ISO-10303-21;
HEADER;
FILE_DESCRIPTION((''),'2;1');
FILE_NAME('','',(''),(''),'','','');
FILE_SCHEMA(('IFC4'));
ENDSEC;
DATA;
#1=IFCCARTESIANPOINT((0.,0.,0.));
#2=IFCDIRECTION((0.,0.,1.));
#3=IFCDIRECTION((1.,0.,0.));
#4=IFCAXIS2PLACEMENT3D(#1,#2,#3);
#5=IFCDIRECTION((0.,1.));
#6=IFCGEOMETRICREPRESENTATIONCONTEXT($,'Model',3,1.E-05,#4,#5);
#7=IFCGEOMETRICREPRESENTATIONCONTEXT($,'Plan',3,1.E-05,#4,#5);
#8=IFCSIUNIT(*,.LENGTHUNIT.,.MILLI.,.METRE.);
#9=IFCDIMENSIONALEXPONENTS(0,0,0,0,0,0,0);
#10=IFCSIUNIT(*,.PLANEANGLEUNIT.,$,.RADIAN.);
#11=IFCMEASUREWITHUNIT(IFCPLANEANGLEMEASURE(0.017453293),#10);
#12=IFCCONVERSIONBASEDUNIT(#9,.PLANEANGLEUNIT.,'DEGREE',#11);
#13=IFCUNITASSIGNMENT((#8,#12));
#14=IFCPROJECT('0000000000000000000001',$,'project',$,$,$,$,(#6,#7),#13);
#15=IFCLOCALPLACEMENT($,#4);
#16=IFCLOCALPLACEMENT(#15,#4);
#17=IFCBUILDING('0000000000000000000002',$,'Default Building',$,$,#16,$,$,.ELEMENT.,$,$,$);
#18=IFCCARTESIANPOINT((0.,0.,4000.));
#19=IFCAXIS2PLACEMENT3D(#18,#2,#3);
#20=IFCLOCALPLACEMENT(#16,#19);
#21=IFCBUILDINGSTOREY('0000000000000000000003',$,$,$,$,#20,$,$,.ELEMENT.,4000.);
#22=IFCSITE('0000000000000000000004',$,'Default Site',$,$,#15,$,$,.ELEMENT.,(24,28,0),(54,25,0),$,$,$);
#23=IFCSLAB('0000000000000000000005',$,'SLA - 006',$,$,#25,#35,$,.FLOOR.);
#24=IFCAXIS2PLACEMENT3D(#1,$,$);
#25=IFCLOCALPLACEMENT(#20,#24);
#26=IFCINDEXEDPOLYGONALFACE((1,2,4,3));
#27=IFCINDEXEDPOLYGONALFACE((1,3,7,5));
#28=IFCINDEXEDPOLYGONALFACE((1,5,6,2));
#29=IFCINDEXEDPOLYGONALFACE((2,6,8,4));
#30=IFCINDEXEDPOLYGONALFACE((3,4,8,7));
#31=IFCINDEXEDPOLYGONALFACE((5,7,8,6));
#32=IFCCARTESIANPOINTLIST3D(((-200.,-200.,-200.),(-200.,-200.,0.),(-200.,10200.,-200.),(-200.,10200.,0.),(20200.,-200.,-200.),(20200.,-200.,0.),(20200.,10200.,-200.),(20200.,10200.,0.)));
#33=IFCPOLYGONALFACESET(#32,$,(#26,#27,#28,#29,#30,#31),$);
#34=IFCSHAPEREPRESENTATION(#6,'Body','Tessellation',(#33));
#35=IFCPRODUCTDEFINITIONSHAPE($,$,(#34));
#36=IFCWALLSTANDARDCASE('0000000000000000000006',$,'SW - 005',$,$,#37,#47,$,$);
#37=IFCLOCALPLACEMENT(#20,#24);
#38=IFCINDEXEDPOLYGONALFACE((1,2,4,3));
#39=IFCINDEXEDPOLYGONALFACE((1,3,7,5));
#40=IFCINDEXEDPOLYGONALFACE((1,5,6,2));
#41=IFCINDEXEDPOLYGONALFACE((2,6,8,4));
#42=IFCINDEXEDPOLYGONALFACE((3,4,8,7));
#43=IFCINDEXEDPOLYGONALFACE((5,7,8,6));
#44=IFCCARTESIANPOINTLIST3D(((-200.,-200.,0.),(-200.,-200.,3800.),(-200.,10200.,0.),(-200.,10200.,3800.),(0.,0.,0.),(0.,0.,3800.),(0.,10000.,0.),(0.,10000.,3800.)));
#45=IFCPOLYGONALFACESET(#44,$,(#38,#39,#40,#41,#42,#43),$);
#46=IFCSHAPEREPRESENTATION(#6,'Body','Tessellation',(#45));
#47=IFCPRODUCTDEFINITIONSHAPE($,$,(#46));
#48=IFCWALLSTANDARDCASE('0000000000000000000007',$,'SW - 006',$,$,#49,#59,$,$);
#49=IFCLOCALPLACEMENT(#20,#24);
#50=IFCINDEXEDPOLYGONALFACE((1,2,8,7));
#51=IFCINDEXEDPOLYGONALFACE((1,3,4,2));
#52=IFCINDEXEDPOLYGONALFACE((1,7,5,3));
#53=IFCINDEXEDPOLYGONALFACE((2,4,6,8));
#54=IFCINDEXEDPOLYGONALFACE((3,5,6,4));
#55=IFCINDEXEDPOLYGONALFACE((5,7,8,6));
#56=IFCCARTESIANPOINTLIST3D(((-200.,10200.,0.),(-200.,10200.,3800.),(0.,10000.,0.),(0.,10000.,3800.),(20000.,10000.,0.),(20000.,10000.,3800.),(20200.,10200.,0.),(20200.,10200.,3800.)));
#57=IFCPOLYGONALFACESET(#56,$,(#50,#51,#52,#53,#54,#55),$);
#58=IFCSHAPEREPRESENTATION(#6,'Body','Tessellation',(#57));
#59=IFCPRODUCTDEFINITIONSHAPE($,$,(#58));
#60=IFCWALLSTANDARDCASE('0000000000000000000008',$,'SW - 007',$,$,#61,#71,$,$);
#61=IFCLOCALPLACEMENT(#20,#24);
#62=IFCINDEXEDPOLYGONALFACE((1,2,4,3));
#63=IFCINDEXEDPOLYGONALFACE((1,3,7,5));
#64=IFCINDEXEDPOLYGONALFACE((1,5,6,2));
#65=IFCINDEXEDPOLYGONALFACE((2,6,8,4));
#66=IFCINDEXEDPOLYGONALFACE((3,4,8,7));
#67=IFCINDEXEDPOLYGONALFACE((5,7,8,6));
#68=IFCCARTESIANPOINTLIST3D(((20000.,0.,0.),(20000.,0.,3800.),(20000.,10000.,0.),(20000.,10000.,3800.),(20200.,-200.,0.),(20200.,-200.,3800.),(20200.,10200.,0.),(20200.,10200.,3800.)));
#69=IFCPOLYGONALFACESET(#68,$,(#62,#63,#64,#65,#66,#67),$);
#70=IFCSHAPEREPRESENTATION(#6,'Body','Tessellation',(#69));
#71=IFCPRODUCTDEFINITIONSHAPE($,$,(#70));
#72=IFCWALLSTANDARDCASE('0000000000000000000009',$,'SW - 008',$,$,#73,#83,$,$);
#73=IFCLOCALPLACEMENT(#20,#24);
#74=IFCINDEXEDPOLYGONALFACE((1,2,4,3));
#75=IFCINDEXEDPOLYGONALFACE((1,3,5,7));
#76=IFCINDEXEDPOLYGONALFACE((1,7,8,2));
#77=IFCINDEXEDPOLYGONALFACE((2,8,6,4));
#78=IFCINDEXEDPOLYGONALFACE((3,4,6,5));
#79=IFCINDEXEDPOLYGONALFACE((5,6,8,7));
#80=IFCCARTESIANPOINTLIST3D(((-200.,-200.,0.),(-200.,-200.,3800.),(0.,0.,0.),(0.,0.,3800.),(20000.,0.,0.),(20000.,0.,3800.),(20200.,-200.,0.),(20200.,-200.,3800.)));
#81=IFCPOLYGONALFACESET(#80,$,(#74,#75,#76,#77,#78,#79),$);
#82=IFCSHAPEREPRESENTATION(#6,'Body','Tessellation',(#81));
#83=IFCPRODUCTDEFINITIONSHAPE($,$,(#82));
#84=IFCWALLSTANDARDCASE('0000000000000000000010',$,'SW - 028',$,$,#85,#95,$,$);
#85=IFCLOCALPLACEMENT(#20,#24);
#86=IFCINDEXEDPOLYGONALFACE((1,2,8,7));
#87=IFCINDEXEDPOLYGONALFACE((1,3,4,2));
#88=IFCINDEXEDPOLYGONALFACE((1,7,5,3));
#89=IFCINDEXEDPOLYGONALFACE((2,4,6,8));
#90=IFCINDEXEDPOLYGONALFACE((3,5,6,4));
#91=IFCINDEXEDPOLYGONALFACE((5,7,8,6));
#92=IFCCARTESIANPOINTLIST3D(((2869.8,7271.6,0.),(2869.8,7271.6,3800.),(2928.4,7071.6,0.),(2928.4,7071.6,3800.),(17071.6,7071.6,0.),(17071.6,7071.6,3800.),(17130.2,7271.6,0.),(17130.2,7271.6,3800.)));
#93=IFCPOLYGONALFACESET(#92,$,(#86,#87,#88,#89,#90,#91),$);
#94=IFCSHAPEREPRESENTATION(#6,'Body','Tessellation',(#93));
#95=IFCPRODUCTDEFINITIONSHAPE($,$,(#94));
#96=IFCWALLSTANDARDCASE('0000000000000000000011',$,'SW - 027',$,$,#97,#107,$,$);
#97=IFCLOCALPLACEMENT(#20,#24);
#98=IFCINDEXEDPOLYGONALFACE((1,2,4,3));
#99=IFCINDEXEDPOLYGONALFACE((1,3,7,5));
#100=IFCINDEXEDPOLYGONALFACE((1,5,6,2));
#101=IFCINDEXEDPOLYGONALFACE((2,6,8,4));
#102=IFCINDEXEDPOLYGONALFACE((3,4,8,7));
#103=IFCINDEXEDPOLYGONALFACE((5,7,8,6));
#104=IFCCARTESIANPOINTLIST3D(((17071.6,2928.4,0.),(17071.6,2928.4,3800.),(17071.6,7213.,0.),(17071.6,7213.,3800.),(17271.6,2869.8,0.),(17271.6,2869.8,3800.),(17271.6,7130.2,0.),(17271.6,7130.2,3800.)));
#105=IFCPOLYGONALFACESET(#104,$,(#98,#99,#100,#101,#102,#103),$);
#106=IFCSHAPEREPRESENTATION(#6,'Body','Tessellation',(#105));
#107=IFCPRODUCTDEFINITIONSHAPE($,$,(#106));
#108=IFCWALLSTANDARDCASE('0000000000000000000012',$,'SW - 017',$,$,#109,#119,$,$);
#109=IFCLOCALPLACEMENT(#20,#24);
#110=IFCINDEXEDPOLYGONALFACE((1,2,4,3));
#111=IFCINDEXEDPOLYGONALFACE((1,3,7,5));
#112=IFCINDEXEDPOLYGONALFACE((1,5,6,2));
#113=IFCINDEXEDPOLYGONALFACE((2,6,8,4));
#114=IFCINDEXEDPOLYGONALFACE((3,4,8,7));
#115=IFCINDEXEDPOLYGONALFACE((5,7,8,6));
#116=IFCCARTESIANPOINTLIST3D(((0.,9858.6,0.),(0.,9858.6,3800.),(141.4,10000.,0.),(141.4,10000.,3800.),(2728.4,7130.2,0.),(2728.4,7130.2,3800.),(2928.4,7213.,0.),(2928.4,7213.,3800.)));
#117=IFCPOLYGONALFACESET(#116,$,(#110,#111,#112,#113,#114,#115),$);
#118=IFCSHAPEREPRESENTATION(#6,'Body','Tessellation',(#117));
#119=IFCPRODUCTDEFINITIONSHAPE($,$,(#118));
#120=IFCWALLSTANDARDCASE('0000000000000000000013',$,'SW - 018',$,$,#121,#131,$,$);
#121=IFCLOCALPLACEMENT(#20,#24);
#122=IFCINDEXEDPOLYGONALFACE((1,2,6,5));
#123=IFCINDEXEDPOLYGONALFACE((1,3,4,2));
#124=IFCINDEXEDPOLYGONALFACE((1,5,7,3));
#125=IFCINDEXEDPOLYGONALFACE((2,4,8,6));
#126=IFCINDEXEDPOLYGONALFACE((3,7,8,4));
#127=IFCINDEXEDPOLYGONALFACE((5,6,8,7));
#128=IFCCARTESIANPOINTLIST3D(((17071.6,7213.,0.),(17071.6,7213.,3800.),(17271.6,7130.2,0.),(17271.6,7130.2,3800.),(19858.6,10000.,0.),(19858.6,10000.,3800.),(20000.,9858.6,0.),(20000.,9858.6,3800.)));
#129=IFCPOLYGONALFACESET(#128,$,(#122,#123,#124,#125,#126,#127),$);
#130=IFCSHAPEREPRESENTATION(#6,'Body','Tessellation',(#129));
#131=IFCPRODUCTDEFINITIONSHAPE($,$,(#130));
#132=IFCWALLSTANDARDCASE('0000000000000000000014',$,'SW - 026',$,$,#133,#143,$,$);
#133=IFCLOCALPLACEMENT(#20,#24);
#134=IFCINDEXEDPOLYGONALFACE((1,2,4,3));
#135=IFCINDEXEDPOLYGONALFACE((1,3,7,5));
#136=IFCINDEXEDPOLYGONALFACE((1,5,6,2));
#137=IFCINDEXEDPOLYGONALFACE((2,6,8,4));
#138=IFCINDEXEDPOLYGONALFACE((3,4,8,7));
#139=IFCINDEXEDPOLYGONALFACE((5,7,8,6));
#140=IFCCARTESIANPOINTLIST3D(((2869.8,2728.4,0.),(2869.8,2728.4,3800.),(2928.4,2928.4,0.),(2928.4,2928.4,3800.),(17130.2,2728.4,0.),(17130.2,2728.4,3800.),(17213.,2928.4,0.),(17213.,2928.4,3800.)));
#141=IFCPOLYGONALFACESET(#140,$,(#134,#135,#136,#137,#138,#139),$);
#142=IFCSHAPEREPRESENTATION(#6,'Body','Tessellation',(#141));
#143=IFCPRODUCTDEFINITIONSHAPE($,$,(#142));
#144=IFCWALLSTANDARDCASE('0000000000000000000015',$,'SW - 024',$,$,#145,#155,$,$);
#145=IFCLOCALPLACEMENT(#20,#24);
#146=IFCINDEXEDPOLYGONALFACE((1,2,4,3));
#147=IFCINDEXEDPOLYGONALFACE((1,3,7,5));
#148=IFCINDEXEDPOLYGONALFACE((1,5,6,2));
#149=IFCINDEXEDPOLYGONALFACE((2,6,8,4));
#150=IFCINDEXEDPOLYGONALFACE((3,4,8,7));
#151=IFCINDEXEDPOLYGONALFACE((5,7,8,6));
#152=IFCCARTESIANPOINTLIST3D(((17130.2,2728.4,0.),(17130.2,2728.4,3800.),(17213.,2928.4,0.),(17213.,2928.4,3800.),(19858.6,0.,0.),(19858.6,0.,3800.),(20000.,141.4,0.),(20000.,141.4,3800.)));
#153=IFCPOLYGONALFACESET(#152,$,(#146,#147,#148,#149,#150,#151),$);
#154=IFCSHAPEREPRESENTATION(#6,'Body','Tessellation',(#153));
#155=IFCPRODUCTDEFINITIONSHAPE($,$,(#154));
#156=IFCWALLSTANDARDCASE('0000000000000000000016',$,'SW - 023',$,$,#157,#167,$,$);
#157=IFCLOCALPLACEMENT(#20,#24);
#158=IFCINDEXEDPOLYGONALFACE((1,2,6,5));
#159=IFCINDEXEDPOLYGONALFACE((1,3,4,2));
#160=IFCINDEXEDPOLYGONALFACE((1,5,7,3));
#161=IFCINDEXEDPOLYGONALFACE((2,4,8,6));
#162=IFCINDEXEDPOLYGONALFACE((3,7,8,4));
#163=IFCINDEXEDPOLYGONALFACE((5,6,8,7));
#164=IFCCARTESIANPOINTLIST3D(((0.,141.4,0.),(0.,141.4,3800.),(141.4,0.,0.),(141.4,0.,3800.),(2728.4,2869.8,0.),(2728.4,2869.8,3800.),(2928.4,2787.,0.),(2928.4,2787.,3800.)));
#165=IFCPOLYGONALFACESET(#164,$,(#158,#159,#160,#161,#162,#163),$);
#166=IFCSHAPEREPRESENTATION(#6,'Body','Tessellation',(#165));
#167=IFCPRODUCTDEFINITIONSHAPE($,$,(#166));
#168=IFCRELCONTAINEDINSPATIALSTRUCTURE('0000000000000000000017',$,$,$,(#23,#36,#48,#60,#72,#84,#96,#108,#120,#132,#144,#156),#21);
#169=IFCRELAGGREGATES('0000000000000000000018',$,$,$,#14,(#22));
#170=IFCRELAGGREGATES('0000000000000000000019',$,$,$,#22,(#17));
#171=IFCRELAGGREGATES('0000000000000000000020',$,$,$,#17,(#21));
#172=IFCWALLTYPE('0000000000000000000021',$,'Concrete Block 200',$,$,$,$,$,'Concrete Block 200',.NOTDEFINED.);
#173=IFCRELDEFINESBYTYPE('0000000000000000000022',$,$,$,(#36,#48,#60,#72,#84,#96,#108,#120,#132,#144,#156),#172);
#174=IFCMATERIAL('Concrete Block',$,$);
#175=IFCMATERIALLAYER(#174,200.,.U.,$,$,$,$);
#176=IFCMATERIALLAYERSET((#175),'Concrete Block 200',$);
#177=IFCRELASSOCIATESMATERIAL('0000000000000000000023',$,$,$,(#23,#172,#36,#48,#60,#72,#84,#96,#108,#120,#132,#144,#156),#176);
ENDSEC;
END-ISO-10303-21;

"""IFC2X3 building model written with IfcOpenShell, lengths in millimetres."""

from ifc_helpers import new_model, entity, si_unit, converted_unit, direction, frame, origin_with_axes, place, context, project, spatial, polyline, outline, extrude, material, layer, layer_set, layer_usage, type_object, element, save


model = new_model("IFC2X3")

# Units and contexts
model_context = context("Model", 3, precision=1e-05, world=origin_with_axes(), true_north=direction((0.0, 1.0)))
plan_context = context("Plan", 3, precision=1e-05, world=origin_with_axes(), true_north=direction((0.0, 1.0)))
ifc_project = project(units=[si_unit("LENGTHUNIT", "METRE", prefix="MILLI"), converted_unit("PLANEANGLEUNIT", "DEGREE", entity("IfcPlaneAngleMeasure", 0.017453293), si_unit("PLANEANGLEUNIT", "RADIAN"), dimensions=[0, 0, 0, 0, 0, 0, 0])], contexts=[model_context, plan_context])

# Site, building, storey
site_placement = place(None, origin_with_axes())
site = spatial("IfcSite", under=ifc_project, at=site_placement, Name="Default Site", CompositionType="ELEMENT", RefLatitude=(24, 28, 0), RefLongitude=(54, 25, 0))
building_placement = place(site_placement, origin_with_axes())
building = spatial("IfcBuilding", under=site, at=building_placement, Name="Default Building", CompositionType="ELEMENT")
storey_placement = place(building_placement, frame((0.0, 0.0, 4000.0), z_axis=(0.0, 0.0, 1.0), x_axis=(1.0, 0.0, 0.0)))
storey = spatial("IfcBuildingStorey", under=building, at=storey_placement, CompositionType="ELEMENT", Elevation=4000.0)

# Slab
ifc_material = material(Name="Concrete Block")
ifc_layer = layer(ifc_material, 200.0, ventilated="UNKNOWN")
ifc_layer_set = layer_set([ifc_layer], Name="Concrete Block 200")
ifc_layer_usage_1 = layer_usage(ifc_layer_set, "AXIS3", "NEGATIVE", 200.0)
slab_placement = place(storey_placement, frame((-200.0, 10200.0, -200.0), z_axis=(0.0, 0.0, 1.0), x_axis=(1.0, 0.0, 0.0)))
element("IfcSlab", 1, at=slab_placement, inside=storey, material=ifc_layer_usage_1, Name="SLA - 006", PredefinedType="FLOOR", context=model_context, shape_type="SweptSolid", body=[
    extrude(outline(polyline([(0.0, 0.0), (20400.0, 0.0), (20400.0, -10400.0), (0.0, -10400.0), (0.0, 0.0)])), origin_with_axes(), (0.0, 0.0, 1.0), 200.0),
])

# Walls
ifc_layer_usage_2 = layer_usage(ifc_layer_set, "AXIS2", "POSITIVE", 0.0)
wall_type = type_object("IfcWallType", Name="Concrete Block 200", ElementType="Concrete Block 200", PredefinedType="NOTDEFINED", material=ifc_layer_set)
wall_1_placement = place(storey_placement, frame((0.0, 0.0, 0.0), z_axis=(0.0, 0.0, 1.0), x_axis=(0.0, 1.0, 0.0)))
element("IfcWallStandardCase", 2, at=wall_1_placement, inside=storey, type_object=wall_type, material=ifc_layer_usage_2, Name="SW - 005", context=model_context, shape_type="SweptSolid", body=[
    extrude(outline(polyline([(0.0, 0.0), (10000.0, 0.0), (10200.0, 200.0), (-200.0, 200.0), (0.0, 0.0)])), origin_with_axes(), (0.0, 0.0, 1.0), 3800.0),
])
ifc_layer_usage_3 = layer_usage(ifc_layer_set, "AXIS2", "POSITIVE", 0.0)
wall_2_placement = place(storey_placement, frame((0.0, 10000.0, 0.0), z_axis=(0.0, 0.0, 1.0), x_axis=(1.0, 0.0, 0.0)))
element("IfcWallStandardCase", 3, at=wall_2_placement, inside=storey, type_object=wall_type, material=ifc_layer_usage_3, Name="SW - 006", context=model_context, shape_type="SweptSolid", body=[
    extrude(outline(polyline([(0.0, 0.0), (20000.0, 0.0), (20200.0, 200.0), (-200.0, 200.0), (0.0, 0.0)])), origin_with_axes(), (0.0, 0.0, 1.0), 3800.0),
])
ifc_layer_usage_4 = layer_usage(ifc_layer_set, "AXIS2", "POSITIVE", 0.0)
wall_3_placement = place(storey_placement, frame((20000.0, 10000.0, 0.0), z_axis=(0.0, 0.0, 1.0), x_axis=(0.0, -1.0, 0.0)))
element("IfcWallStandardCase", 4, at=wall_3_placement, inside=storey, type_object=wall_type, material=ifc_layer_usage_4, Name="SW - 007", context=model_context, shape_type="SweptSolid", body=[
    extrude(outline(polyline([(0.0, 0.0), (10000.0, 0.0), (10200.0, 200.0), (-200.0, 200.0), (0.0, 0.0)])), origin_with_axes(), (0.0, 0.0, 1.0), 3800.0),
])
ifc_layer_usage_5 = layer_usage(ifc_layer_set, "AXIS2", "POSITIVE", 0.0)
wall_4_placement = place(storey_placement, frame((20000.0, 0.0, 0.0), z_axis=(0.0, 0.0, 1.0), x_axis=(-1.0, 0.0, 0.0)))
element("IfcWallStandardCase", 5, at=wall_4_placement, inside=storey, type_object=wall_type, material=ifc_layer_usage_5, Name="SW - 008", context=model_context, shape_type="SweptSolid", body=[
    extrude(outline(polyline([(0.0, 0.0), (20000.0, 0.0), (20200.0, 200.0), (-200.0, 200.0), (0.0, 0.0)])), origin_with_axes(), (0.0, 0.0, 1.0), 3800.0),
])
ifc_layer_usage_6 = layer_usage(ifc_layer_set, "AXIS2", "POSITIVE", 0.0)
wall_5_placement = place(storey_placement, frame((2928.4, 7071.6, 0.0), z_axis=(0.0, 0.0, 1.0), x_axis=(1.0, 0.0, 0.0)))
element("IfcWallStandardCase", 6, at=wall_5_placement, inside=storey, type_object=wall_type, material=ifc_layer_usage_6, Name="SW - 028", context=model_context, shape_type="SweptSolid", body=[
    extrude(outline(polyline([(0.0, 0.0), (14143.1, 0.0), (14201.7, 200.0), (-58.6, 200.0), (0.0, 0.0)])), origin_with_axes(), (0.0, 0.0, 1.0), 3800.0),
])
ifc_layer_usage_7 = layer_usage(ifc_layer_set, "AXIS2", "NEGATIVE", 0.0)
wall_6_placement = place(storey_placement, frame((17071.6, 2928.4, 0.0), z_axis=(0.0, 0.0, 1.0), x_axis=(0.0, 1.0, 0.0)))
element("IfcWallStandardCase", 7, at=wall_6_placement, inside=storey, type_object=wall_type, material=ifc_layer_usage_7, Name="SW - 027", context=model_context, shape_type="SweptSolid", body=[
    extrude(outline(polyline([(-58.6, -200.0), (4201.7, -200.0), (4284.6, 0.0), (0.0, 0.0), (-58.6, -200.0)])), origin_with_axes(), (0.0, 0.0, 1.0), 3800.0),
])
ifc_layer_usage_8 = layer_usage(ifc_layer_set, "AXIS2", "NEGATIVE", 100.0)
wall_7_placement = place(storey_placement, frame((0.0, 10000.0, 0.0), z_axis=(0.0, 0.0, 1.0), x_axis=(0.707107, -0.707107, 0.0)))
element("IfcWallStandardCase", 8, at=wall_7_placement, inside=storey, type_object=wall_type, material=ifc_layer_usage_8, Name="SW - 017", context=model_context, shape_type="SweptSolid", body=[
    extrude(outline(polyline([(100.0, -100.0), (3958.6, -100.0), (4041.4, 100.0), (100.0, 100.0), (100.0, -100.0)])), origin_with_axes(), (0.0, 0.0, 1.0), 3800.0),
])
ifc_layer_usage_9 = layer_usage(ifc_layer_set, "AXIS2", "NEGATIVE", 100.0)
wall_8_placement = place(storey_placement, frame((20000.0, 10000.0, 0.0), z_axis=(0.0, 0.0, 1.0), x_axis=(-0.707107, -0.707107, 0.0)))
element("IfcWallStandardCase", 9, at=wall_8_placement, inside=storey, type_object=wall_type, material=ifc_layer_usage_9, Name="SW - 018", context=model_context, shape_type="SweptSolid", body=[
    extrude(outline(polyline([(100.0, -100.0), (4041.4, -100.0), (3958.6, 100.0), (100.0, 100.0), (100.0, -100.0)])), origin_with_axes(), (0.0, 0.0, 1.0), 3800.0),
])
ifc_layer_usage_10 = layer_usage(ifc_layer_set, "AXIS2", "NEGATIVE", 0.0)
wall_9_placement = place(storey_placement, frame((2928.4, 2928.4, 0.0), z_axis=(0.0, 0.0, 1.0), x_axis=(1.0, 0.0, 0.0)))
element("IfcWallStandardCase", 10, at=wall_9_placement, inside=storey, type_object=wall_type, material=ifc_layer_usage_10, Name="SW - 026", context=model_context, shape_type="SweptSolid", body=[
    extrude(outline(polyline([(-58.6, -200.0), (14201.7, -200.0), (14284.6, 0.0), (0.0, 0.0), (-58.6, -200.0)])), origin_with_axes(), (0.0, 0.0, 1.0), 3800.0),
])
ifc_layer_usage_11 = layer_usage(ifc_layer_set, "AXIS2", "NEGATIVE", 100.0)
wall_10_placement = place(storey_placement, frame((20000.0, 0.0, 0.0), z_axis=(0.0, 0.0, 1.0), x_axis=(-0.707107, 0.707107, 0.0)))
element("IfcWallStandardCase", 11, at=wall_10_placement, inside=storey, type_object=wall_type, material=ifc_layer_usage_11, Name="SW - 024", context=model_context, shape_type="SweptSolid", body=[
    extrude(outline(polyline([(100.0, -100.0), (4041.4, -100.0), (3958.6, 100.0), (100.0, 100.0), (100.0, -100.0)])), origin_with_axes(), (0.0, 0.0, 1.0), 3800.0),
])
ifc_layer_usage_12 = layer_usage(ifc_layer_set, "AXIS2", "NEGATIVE", 100.0)
wall_11_placement = place(storey_placement, frame((0.0, 0.0, 0.0), z_axis=(0.0, 0.0, 1.0), x_axis=(0.707107, 0.707107, 0.0)))
element("IfcWallStandardCase", 12, at=wall_11_placement, inside=storey, type_object=wall_type, material=ifc_layer_usage_12, Name="SW - 023", context=model_context, shape_type="SweptSolid", body=[
    extrude(outline(polyline([(100.0, -100.0), (4041.4, -100.0), (3958.6, 100.0), (100.0, 100.0), (100.0, -100.0)])), origin_with_axes(), (0.0, 0.0, 1.0), 3800.0),
])

save(model, "model.ifc")
